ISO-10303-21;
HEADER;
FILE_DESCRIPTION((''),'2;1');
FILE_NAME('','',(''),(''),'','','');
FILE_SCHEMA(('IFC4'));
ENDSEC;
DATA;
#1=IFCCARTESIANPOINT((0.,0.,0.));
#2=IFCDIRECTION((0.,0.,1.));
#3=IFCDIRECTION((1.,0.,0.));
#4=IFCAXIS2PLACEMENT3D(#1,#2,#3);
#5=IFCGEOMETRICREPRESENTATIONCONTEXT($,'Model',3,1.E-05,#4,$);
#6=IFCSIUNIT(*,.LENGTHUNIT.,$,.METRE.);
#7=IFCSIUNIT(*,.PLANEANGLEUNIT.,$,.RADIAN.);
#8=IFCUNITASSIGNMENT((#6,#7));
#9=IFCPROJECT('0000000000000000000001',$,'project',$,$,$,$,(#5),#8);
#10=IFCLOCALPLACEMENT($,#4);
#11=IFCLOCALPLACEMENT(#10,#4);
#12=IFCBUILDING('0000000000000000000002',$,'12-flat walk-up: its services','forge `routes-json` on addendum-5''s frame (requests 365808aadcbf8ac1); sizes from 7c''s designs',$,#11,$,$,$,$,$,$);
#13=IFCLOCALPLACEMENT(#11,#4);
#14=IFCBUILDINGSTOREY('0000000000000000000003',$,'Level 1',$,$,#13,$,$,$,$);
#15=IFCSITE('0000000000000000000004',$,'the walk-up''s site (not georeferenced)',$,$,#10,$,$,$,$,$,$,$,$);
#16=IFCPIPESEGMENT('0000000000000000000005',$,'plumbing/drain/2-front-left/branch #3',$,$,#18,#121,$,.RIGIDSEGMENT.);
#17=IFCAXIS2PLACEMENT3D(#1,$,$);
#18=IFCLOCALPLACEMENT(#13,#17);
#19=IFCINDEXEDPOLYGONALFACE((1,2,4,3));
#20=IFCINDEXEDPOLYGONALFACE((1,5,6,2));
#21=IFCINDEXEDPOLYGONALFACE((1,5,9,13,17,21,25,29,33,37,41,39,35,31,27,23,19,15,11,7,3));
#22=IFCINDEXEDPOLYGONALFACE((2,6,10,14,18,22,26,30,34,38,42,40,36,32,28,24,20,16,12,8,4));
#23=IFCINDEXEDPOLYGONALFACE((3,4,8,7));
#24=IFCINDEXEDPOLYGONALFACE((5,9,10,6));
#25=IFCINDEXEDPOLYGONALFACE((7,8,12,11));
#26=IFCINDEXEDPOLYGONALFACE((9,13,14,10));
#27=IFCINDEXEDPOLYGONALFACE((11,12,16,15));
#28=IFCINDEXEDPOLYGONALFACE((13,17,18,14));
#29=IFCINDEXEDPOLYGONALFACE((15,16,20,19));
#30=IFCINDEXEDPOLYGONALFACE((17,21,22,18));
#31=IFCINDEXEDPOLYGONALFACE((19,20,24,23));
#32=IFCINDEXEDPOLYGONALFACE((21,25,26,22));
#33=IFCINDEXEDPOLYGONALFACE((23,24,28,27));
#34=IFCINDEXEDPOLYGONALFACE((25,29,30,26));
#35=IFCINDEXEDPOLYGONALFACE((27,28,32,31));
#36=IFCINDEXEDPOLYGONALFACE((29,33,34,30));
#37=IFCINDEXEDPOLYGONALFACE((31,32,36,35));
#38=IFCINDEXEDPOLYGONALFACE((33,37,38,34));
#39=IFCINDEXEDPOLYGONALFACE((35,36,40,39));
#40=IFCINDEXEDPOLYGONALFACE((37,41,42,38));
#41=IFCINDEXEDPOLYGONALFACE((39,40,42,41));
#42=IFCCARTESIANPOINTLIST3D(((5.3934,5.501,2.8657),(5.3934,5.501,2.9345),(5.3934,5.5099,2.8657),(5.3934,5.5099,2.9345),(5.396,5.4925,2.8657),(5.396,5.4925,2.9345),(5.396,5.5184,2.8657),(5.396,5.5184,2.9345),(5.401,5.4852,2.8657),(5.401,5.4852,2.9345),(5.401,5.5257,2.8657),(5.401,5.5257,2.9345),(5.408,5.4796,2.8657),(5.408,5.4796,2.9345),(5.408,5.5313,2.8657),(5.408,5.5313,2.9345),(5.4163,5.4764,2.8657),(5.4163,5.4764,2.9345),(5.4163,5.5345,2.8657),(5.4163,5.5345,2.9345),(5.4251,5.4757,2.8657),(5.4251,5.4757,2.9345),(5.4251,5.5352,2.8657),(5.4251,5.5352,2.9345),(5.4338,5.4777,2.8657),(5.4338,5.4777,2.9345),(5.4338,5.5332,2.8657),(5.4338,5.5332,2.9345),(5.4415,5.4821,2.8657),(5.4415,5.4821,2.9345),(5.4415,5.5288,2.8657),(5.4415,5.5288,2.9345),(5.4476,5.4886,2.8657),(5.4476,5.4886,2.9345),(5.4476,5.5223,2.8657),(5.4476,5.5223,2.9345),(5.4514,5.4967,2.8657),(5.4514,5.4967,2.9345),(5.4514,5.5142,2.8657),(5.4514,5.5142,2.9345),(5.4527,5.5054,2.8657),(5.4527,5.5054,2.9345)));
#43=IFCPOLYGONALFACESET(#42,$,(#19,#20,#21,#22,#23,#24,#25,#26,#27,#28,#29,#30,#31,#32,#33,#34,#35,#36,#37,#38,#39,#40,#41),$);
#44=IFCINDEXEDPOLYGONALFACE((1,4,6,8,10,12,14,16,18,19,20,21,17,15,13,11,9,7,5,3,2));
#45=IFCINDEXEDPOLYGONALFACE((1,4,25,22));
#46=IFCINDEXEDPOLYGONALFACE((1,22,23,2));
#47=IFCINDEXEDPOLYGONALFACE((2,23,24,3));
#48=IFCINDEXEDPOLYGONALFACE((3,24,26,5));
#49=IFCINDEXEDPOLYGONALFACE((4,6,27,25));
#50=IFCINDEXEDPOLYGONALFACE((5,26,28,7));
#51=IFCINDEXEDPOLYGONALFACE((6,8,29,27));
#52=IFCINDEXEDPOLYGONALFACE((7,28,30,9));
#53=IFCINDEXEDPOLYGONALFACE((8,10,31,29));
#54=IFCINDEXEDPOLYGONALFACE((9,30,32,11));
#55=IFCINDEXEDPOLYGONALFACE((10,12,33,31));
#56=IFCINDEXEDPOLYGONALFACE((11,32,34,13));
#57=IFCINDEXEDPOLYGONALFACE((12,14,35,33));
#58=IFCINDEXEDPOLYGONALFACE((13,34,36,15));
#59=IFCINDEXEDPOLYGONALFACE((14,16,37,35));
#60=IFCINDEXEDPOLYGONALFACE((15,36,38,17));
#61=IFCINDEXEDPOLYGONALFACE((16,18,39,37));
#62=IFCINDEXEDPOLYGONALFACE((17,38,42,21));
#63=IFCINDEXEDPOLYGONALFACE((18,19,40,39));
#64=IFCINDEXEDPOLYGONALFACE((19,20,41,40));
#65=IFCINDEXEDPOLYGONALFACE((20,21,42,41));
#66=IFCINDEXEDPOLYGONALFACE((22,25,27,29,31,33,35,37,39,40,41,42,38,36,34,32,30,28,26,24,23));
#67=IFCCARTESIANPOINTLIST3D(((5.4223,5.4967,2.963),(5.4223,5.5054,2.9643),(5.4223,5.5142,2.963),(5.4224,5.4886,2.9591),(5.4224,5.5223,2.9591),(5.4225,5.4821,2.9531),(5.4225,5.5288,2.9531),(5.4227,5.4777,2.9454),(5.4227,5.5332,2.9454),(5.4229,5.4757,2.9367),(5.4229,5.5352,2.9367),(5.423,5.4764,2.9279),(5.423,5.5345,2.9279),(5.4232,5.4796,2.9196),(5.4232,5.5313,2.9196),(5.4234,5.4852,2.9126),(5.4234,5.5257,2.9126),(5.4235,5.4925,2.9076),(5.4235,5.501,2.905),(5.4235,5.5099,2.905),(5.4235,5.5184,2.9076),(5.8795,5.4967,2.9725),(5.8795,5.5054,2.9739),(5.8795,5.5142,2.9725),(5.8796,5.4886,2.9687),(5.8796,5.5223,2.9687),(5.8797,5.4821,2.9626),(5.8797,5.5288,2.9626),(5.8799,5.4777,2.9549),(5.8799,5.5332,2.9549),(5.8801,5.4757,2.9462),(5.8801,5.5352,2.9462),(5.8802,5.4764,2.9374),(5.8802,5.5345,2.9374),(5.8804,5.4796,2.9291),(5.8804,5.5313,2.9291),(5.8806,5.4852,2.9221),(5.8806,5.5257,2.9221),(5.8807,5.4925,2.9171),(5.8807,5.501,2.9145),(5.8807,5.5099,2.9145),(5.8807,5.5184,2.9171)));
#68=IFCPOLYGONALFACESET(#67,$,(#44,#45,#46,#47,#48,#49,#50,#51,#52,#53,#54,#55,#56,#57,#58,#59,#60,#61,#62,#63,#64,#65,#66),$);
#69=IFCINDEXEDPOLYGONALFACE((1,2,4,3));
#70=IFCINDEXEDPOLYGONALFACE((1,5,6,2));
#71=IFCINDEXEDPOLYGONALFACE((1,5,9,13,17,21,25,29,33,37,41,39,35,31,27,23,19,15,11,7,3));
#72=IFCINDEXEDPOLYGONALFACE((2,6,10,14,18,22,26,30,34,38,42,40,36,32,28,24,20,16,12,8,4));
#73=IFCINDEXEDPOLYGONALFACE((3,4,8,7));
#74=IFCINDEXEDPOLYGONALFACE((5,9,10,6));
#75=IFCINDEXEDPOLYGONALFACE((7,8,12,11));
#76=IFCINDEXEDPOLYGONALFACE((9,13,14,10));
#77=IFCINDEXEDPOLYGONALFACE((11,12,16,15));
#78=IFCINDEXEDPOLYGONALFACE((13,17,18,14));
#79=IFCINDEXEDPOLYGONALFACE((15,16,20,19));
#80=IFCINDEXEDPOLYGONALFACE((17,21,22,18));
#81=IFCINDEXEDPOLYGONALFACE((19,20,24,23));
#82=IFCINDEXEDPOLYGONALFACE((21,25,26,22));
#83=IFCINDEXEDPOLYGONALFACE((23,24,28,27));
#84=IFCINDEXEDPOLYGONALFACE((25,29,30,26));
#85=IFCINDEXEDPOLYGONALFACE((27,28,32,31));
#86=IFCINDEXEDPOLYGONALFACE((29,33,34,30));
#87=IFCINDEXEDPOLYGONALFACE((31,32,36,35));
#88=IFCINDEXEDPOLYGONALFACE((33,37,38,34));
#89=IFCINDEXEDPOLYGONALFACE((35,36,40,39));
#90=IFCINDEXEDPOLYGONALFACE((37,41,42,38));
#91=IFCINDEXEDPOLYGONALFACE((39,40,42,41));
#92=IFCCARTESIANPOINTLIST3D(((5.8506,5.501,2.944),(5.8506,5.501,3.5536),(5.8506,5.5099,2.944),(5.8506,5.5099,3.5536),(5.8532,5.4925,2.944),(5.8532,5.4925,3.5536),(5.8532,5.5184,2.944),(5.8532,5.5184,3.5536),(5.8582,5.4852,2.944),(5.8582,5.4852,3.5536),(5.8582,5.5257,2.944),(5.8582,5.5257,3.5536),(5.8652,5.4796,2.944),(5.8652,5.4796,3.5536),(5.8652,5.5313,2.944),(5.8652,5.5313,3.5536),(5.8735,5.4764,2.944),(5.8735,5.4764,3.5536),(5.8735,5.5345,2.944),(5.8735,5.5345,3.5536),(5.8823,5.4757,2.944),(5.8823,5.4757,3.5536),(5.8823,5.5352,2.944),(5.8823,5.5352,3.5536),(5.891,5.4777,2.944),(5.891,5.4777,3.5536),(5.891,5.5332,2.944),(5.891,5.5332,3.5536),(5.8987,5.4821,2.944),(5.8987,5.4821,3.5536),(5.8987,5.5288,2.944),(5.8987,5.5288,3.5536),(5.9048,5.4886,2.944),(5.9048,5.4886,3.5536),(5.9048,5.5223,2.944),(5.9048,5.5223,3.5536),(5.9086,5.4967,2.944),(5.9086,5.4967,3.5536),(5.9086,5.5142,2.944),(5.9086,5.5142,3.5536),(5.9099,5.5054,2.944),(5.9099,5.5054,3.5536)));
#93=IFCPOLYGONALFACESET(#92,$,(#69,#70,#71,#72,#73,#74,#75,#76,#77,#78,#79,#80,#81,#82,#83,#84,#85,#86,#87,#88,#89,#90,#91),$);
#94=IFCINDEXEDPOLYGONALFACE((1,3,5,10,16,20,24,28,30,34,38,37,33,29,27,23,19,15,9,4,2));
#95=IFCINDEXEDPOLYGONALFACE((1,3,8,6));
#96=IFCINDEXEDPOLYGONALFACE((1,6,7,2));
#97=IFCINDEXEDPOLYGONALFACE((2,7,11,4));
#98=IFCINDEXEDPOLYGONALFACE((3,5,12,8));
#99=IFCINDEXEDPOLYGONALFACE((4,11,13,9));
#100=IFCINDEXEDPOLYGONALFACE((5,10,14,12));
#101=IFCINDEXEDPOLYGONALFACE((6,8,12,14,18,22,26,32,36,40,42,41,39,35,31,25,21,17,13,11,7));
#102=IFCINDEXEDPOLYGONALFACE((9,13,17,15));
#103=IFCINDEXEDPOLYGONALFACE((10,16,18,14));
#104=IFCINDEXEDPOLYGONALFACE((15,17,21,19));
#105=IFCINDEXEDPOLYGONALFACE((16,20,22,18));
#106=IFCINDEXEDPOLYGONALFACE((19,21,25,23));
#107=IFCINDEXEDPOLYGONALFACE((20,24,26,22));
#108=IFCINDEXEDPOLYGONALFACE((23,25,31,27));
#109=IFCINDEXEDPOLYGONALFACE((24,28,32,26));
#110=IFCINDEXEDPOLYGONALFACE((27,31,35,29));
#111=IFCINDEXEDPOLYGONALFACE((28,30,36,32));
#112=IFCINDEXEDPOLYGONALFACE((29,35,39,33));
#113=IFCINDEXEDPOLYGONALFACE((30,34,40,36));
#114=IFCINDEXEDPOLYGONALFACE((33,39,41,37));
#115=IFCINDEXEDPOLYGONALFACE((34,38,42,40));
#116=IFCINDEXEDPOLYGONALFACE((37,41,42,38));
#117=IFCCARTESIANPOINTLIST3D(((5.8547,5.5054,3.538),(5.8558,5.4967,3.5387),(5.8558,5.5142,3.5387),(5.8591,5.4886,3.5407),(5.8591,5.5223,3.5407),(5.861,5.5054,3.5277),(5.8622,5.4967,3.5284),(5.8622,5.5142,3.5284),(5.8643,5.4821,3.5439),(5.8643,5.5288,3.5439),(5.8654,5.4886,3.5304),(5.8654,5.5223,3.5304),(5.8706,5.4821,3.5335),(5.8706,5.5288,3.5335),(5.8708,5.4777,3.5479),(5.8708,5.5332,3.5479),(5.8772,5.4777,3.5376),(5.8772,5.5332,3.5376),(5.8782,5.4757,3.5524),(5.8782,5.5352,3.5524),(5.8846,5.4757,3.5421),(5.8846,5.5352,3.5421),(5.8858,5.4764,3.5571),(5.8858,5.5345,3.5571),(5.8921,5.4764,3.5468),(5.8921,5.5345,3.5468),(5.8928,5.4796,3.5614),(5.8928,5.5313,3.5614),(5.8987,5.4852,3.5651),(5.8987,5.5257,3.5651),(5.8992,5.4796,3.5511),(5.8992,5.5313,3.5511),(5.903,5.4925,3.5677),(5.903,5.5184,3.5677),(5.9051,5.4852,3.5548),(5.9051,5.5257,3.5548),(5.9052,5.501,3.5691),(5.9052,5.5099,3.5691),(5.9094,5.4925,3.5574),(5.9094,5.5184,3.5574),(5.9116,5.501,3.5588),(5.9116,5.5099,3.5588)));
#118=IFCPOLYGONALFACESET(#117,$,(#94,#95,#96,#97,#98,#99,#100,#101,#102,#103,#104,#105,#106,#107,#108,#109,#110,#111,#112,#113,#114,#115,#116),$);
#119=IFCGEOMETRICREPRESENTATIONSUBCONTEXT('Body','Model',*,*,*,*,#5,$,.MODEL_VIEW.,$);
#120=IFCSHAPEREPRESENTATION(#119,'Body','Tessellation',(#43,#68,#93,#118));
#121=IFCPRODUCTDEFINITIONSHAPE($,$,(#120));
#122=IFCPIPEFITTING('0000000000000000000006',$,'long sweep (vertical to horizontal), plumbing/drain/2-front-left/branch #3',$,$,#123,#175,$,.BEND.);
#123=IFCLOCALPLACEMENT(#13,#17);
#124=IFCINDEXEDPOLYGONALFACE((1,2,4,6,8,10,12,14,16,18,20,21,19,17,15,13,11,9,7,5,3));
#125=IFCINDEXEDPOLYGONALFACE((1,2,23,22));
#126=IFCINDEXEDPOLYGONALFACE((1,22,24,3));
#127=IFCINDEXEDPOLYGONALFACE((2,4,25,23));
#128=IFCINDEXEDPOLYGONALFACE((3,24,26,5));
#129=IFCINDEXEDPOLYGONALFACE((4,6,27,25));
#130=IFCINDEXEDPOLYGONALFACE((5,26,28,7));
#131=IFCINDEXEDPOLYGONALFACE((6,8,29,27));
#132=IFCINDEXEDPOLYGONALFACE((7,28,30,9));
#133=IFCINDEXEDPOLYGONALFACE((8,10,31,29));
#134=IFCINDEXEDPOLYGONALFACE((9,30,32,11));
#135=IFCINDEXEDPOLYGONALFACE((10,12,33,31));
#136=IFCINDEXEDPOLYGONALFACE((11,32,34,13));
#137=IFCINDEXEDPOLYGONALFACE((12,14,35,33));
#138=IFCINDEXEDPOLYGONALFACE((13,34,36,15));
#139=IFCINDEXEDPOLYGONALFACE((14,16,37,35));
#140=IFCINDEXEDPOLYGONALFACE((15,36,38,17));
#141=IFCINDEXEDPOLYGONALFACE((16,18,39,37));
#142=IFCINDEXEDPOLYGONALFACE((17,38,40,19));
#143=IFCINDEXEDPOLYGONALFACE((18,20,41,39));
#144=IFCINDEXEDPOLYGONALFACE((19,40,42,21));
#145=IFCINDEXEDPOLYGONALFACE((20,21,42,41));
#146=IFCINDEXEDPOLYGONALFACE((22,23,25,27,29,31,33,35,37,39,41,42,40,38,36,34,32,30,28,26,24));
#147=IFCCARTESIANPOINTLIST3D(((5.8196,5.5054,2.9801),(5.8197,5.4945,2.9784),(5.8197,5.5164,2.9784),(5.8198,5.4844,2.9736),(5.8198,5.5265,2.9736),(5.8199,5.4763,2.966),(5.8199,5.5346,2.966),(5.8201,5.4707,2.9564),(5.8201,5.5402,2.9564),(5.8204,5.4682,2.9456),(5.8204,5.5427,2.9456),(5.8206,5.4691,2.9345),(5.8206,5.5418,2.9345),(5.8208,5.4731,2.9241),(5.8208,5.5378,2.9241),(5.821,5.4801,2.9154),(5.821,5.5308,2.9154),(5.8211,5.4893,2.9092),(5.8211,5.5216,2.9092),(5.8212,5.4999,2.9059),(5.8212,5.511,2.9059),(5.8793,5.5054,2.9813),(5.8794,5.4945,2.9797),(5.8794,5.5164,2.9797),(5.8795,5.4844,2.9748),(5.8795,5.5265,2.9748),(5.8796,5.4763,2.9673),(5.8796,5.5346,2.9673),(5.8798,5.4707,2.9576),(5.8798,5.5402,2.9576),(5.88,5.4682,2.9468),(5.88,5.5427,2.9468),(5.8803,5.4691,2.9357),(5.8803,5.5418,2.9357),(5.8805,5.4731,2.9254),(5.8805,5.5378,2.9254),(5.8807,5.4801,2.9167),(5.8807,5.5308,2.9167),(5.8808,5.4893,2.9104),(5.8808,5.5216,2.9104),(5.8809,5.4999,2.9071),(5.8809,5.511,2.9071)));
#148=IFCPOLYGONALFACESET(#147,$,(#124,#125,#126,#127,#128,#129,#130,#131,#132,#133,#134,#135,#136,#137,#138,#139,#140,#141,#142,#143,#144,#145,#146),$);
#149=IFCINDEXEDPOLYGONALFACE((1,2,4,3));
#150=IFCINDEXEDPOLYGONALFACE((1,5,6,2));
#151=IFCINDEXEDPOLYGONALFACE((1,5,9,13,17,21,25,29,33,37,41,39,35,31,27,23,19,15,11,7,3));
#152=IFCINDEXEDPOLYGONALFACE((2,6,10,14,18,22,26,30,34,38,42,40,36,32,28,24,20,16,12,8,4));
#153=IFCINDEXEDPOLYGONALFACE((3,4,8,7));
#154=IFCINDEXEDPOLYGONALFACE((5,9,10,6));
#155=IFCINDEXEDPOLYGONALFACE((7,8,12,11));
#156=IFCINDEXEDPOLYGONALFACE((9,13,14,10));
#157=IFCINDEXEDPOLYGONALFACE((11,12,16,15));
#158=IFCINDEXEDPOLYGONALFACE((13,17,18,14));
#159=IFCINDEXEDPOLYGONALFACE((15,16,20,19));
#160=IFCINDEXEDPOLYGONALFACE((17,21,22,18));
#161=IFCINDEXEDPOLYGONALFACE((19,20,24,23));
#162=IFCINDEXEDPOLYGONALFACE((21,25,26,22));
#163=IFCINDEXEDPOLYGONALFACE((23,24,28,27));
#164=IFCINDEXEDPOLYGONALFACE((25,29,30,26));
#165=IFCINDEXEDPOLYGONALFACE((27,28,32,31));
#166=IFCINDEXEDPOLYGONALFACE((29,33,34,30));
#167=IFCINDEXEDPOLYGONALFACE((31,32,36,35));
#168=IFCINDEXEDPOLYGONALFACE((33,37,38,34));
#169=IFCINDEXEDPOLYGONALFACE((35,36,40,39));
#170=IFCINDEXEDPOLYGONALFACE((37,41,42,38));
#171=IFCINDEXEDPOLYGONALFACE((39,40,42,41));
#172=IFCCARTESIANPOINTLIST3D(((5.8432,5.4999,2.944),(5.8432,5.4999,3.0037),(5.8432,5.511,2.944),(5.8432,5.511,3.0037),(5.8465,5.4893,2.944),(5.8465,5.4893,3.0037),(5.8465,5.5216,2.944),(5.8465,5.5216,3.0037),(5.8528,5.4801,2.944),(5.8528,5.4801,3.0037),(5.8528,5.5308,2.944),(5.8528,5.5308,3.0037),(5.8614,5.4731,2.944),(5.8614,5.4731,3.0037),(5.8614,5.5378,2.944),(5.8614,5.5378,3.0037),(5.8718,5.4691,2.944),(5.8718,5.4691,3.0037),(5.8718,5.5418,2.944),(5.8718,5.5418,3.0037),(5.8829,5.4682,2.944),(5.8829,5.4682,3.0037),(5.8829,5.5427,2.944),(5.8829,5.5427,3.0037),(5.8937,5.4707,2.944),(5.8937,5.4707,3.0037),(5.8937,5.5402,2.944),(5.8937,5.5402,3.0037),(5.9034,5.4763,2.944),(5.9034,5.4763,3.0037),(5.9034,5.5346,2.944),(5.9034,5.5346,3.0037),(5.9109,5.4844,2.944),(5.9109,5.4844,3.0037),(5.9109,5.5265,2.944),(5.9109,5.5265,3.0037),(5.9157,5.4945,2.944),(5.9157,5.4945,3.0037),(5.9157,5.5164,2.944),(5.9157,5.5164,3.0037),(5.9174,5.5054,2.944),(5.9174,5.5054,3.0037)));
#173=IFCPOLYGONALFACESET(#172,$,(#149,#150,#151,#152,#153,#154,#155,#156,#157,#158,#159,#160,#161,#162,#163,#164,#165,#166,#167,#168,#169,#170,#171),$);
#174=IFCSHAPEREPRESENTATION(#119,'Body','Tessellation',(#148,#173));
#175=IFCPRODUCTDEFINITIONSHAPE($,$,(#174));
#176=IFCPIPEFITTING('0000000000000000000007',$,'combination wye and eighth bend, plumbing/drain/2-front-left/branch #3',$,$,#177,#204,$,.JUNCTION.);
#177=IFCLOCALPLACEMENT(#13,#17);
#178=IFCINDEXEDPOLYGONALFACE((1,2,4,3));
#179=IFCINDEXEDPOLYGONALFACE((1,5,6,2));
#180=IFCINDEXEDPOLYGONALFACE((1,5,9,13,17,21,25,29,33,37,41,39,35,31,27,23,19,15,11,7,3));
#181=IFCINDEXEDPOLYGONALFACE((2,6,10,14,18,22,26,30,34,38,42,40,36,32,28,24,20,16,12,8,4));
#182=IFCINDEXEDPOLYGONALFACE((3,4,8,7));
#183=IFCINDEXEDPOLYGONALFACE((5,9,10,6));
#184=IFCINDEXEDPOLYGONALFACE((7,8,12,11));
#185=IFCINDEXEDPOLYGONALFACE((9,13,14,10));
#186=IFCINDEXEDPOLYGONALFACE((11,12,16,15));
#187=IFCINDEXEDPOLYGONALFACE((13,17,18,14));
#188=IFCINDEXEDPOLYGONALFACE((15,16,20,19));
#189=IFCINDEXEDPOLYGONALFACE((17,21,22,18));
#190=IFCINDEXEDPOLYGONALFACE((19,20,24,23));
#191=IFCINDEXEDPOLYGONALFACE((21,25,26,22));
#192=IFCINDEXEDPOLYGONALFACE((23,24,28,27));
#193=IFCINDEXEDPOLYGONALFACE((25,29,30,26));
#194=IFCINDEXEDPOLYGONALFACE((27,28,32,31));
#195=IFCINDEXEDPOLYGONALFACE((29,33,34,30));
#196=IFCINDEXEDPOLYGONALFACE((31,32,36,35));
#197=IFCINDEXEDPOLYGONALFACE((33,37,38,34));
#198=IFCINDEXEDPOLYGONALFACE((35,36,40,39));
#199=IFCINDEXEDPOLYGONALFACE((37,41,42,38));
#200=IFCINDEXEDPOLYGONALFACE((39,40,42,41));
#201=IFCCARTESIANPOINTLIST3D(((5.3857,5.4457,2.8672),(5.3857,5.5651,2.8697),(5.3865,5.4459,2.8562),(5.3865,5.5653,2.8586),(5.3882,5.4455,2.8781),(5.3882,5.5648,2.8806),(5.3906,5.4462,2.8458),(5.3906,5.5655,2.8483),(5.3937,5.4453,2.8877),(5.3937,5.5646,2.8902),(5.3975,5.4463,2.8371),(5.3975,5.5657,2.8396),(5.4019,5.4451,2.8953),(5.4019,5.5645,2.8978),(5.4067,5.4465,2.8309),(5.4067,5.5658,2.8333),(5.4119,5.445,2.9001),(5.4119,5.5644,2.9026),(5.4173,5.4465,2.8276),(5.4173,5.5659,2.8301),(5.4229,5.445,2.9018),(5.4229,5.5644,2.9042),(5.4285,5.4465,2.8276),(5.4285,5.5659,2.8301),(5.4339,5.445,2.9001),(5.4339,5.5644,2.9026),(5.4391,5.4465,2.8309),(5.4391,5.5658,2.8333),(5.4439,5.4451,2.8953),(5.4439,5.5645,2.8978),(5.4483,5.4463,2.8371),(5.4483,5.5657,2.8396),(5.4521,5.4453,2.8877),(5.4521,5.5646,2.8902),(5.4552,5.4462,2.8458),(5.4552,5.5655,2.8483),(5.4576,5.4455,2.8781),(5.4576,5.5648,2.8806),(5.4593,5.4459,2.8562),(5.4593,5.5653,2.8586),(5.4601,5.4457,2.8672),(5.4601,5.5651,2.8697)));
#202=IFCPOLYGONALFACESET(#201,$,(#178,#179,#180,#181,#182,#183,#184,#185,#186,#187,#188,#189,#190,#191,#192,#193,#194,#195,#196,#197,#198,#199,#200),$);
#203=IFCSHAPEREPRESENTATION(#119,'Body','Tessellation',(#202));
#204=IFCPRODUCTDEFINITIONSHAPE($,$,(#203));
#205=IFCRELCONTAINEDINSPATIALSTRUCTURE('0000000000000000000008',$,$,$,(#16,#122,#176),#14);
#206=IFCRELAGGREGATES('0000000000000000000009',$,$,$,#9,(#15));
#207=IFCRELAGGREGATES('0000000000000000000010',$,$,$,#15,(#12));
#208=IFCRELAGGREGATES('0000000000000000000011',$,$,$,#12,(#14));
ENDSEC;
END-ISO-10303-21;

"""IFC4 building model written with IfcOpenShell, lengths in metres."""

from ifc_helpers import new_model, entity, si_unit, frame, origin_with_axes, place, context, subcontext, project, spatial, element, save


model = new_model("IFC4")

# Units and contexts
model_context = context("Model", 3, precision=1e-05, world=origin_with_axes())
body_context = subcontext(model_context, "Body", "Model", "MODEL_VIEW")
ifc_project = project(units=[si_unit("LENGTHUNIT", "METRE"), si_unit("PLANEANGLEUNIT", "RADIAN")], contexts=[model_context])

# Site, building, storey
site_placement = place(None, origin_with_axes())
site = spatial("IfcSite", under=ifc_project, at=site_placement, Name="the walk-up's site (not georeferenced)")
building_placement = place(site_placement, origin_with_axes())
building = spatial("IfcBuilding", under=site, at=building_placement, Name="12-flat walk-up: its services", Description="forge `routes-json` on addendum-5's frame (requests 365808aadcbf8ac1); sizes from 7c's designs")
storey_placement = place(building_placement, origin_with_axes())
storey = spatial("IfcBuildingStorey", under=building, at=storey_placement, Name="Level 1")

# Pipe segment
pipe_segment_1_placement = place(storey_placement, frame((5.4229, 5.5054, 2.8657), z_axis=(0.0, 0.0, 1.0), x_axis=(1.0, 0.0, 0.0)))
element("IfcPipeSegment", 1, at=pipe_segment_1_placement, inside=storey, Name="plumbing/drain/2-front-left/branch #3", PredefinedType="RIGIDSEGMENT", context=body_context, shape_type="AdvancedSweptSolid", body=[
    entity("IfcSweptDiskSolid", entity("IfcPolyline", [entity("IfcCartesianPoint", [0.0, 0.0, 0.0]), entity("IfcCartesianPoint", [0.0, 0.0, 0.0688])]), 0.0298),
    entity("IfcSweptDiskSolid", entity("IfcPolyline", [entity("IfcCartesianPoint", [0.0, 0.0, 0.0688]), entity("IfcCartesianPoint", [0.4572, 0.0, 0.0783])]), 0.0298),
    entity("IfcSweptDiskSolid", entity("IfcPolyline", [entity("IfcCartesianPoint", [0.4572, 0.0, 0.0783]), entity("IfcCartesianPoint", [0.4572, 0.0, 0.6879])]), 0.0298),
    entity("IfcSweptDiskSolid", entity("IfcPolyline", [entity("IfcCartesianPoint", [0.4572, 0.0, 0.6879]), entity("IfcCartesianPoint", [0.4635, 0.0, 0.6776])]), 0.0298),
])

# Pipe fittings
pipe_fitting_1_placement = place(storey_placement, frame((5.8204, 5.5054, 2.9428), z_axis=(0.0, 0.0, 1.0), x_axis=(1.0, 0.0, 0.0)))
element("IfcPipeFitting", 2, at=pipe_fitting_1_placement, inside=storey, Name="long sweep (vertical to horizontal), plumbing/drain/2-front-left/branch #3", PredefinedType="BEND", context=body_context, shape_type="AdvancedSweptSolid", body=[
    entity("IfcSweptDiskSolid", entity("IfcPolyline", [entity("IfcCartesianPoint", [0.0, 0.0, 0.0]), entity("IfcCartesianPoint", [0.0597, 0.0, 0.0012])]), 0.0373),
    entity("IfcSweptDiskSolid", entity("IfcPolyline", [entity("IfcCartesianPoint", [0.0597, 0.0, 0.0012]), entity("IfcCartesianPoint", [0.0597, 0.0, 0.0609])]), 0.0373),
])
pipe_fitting_2_placement = place(storey_placement, frame((5.4229, 5.4458, 2.8645), z_axis=(0.0, 0.0, 1.0), x_axis=(1.0, 0.0, 0.0)))
element("IfcPipeFitting", 3, at=pipe_fitting_2_placement, inside=storey, Name="combination wye and eighth bend, plumbing/drain/2-front-left/branch #3", PredefinedType="JUNCTION", context=body_context, shape_type="AdvancedSweptSolid", body=[
    entity("IfcSweptDiskSolid", entity("IfcPolyline", [entity("IfcCartesianPoint", [0.0, 0.0, 0.0]), entity("IfcCartesianPoint", [0.0, 0.1194, 0.0025])]), 0.0373),
])

save(model, "model.ifc")
